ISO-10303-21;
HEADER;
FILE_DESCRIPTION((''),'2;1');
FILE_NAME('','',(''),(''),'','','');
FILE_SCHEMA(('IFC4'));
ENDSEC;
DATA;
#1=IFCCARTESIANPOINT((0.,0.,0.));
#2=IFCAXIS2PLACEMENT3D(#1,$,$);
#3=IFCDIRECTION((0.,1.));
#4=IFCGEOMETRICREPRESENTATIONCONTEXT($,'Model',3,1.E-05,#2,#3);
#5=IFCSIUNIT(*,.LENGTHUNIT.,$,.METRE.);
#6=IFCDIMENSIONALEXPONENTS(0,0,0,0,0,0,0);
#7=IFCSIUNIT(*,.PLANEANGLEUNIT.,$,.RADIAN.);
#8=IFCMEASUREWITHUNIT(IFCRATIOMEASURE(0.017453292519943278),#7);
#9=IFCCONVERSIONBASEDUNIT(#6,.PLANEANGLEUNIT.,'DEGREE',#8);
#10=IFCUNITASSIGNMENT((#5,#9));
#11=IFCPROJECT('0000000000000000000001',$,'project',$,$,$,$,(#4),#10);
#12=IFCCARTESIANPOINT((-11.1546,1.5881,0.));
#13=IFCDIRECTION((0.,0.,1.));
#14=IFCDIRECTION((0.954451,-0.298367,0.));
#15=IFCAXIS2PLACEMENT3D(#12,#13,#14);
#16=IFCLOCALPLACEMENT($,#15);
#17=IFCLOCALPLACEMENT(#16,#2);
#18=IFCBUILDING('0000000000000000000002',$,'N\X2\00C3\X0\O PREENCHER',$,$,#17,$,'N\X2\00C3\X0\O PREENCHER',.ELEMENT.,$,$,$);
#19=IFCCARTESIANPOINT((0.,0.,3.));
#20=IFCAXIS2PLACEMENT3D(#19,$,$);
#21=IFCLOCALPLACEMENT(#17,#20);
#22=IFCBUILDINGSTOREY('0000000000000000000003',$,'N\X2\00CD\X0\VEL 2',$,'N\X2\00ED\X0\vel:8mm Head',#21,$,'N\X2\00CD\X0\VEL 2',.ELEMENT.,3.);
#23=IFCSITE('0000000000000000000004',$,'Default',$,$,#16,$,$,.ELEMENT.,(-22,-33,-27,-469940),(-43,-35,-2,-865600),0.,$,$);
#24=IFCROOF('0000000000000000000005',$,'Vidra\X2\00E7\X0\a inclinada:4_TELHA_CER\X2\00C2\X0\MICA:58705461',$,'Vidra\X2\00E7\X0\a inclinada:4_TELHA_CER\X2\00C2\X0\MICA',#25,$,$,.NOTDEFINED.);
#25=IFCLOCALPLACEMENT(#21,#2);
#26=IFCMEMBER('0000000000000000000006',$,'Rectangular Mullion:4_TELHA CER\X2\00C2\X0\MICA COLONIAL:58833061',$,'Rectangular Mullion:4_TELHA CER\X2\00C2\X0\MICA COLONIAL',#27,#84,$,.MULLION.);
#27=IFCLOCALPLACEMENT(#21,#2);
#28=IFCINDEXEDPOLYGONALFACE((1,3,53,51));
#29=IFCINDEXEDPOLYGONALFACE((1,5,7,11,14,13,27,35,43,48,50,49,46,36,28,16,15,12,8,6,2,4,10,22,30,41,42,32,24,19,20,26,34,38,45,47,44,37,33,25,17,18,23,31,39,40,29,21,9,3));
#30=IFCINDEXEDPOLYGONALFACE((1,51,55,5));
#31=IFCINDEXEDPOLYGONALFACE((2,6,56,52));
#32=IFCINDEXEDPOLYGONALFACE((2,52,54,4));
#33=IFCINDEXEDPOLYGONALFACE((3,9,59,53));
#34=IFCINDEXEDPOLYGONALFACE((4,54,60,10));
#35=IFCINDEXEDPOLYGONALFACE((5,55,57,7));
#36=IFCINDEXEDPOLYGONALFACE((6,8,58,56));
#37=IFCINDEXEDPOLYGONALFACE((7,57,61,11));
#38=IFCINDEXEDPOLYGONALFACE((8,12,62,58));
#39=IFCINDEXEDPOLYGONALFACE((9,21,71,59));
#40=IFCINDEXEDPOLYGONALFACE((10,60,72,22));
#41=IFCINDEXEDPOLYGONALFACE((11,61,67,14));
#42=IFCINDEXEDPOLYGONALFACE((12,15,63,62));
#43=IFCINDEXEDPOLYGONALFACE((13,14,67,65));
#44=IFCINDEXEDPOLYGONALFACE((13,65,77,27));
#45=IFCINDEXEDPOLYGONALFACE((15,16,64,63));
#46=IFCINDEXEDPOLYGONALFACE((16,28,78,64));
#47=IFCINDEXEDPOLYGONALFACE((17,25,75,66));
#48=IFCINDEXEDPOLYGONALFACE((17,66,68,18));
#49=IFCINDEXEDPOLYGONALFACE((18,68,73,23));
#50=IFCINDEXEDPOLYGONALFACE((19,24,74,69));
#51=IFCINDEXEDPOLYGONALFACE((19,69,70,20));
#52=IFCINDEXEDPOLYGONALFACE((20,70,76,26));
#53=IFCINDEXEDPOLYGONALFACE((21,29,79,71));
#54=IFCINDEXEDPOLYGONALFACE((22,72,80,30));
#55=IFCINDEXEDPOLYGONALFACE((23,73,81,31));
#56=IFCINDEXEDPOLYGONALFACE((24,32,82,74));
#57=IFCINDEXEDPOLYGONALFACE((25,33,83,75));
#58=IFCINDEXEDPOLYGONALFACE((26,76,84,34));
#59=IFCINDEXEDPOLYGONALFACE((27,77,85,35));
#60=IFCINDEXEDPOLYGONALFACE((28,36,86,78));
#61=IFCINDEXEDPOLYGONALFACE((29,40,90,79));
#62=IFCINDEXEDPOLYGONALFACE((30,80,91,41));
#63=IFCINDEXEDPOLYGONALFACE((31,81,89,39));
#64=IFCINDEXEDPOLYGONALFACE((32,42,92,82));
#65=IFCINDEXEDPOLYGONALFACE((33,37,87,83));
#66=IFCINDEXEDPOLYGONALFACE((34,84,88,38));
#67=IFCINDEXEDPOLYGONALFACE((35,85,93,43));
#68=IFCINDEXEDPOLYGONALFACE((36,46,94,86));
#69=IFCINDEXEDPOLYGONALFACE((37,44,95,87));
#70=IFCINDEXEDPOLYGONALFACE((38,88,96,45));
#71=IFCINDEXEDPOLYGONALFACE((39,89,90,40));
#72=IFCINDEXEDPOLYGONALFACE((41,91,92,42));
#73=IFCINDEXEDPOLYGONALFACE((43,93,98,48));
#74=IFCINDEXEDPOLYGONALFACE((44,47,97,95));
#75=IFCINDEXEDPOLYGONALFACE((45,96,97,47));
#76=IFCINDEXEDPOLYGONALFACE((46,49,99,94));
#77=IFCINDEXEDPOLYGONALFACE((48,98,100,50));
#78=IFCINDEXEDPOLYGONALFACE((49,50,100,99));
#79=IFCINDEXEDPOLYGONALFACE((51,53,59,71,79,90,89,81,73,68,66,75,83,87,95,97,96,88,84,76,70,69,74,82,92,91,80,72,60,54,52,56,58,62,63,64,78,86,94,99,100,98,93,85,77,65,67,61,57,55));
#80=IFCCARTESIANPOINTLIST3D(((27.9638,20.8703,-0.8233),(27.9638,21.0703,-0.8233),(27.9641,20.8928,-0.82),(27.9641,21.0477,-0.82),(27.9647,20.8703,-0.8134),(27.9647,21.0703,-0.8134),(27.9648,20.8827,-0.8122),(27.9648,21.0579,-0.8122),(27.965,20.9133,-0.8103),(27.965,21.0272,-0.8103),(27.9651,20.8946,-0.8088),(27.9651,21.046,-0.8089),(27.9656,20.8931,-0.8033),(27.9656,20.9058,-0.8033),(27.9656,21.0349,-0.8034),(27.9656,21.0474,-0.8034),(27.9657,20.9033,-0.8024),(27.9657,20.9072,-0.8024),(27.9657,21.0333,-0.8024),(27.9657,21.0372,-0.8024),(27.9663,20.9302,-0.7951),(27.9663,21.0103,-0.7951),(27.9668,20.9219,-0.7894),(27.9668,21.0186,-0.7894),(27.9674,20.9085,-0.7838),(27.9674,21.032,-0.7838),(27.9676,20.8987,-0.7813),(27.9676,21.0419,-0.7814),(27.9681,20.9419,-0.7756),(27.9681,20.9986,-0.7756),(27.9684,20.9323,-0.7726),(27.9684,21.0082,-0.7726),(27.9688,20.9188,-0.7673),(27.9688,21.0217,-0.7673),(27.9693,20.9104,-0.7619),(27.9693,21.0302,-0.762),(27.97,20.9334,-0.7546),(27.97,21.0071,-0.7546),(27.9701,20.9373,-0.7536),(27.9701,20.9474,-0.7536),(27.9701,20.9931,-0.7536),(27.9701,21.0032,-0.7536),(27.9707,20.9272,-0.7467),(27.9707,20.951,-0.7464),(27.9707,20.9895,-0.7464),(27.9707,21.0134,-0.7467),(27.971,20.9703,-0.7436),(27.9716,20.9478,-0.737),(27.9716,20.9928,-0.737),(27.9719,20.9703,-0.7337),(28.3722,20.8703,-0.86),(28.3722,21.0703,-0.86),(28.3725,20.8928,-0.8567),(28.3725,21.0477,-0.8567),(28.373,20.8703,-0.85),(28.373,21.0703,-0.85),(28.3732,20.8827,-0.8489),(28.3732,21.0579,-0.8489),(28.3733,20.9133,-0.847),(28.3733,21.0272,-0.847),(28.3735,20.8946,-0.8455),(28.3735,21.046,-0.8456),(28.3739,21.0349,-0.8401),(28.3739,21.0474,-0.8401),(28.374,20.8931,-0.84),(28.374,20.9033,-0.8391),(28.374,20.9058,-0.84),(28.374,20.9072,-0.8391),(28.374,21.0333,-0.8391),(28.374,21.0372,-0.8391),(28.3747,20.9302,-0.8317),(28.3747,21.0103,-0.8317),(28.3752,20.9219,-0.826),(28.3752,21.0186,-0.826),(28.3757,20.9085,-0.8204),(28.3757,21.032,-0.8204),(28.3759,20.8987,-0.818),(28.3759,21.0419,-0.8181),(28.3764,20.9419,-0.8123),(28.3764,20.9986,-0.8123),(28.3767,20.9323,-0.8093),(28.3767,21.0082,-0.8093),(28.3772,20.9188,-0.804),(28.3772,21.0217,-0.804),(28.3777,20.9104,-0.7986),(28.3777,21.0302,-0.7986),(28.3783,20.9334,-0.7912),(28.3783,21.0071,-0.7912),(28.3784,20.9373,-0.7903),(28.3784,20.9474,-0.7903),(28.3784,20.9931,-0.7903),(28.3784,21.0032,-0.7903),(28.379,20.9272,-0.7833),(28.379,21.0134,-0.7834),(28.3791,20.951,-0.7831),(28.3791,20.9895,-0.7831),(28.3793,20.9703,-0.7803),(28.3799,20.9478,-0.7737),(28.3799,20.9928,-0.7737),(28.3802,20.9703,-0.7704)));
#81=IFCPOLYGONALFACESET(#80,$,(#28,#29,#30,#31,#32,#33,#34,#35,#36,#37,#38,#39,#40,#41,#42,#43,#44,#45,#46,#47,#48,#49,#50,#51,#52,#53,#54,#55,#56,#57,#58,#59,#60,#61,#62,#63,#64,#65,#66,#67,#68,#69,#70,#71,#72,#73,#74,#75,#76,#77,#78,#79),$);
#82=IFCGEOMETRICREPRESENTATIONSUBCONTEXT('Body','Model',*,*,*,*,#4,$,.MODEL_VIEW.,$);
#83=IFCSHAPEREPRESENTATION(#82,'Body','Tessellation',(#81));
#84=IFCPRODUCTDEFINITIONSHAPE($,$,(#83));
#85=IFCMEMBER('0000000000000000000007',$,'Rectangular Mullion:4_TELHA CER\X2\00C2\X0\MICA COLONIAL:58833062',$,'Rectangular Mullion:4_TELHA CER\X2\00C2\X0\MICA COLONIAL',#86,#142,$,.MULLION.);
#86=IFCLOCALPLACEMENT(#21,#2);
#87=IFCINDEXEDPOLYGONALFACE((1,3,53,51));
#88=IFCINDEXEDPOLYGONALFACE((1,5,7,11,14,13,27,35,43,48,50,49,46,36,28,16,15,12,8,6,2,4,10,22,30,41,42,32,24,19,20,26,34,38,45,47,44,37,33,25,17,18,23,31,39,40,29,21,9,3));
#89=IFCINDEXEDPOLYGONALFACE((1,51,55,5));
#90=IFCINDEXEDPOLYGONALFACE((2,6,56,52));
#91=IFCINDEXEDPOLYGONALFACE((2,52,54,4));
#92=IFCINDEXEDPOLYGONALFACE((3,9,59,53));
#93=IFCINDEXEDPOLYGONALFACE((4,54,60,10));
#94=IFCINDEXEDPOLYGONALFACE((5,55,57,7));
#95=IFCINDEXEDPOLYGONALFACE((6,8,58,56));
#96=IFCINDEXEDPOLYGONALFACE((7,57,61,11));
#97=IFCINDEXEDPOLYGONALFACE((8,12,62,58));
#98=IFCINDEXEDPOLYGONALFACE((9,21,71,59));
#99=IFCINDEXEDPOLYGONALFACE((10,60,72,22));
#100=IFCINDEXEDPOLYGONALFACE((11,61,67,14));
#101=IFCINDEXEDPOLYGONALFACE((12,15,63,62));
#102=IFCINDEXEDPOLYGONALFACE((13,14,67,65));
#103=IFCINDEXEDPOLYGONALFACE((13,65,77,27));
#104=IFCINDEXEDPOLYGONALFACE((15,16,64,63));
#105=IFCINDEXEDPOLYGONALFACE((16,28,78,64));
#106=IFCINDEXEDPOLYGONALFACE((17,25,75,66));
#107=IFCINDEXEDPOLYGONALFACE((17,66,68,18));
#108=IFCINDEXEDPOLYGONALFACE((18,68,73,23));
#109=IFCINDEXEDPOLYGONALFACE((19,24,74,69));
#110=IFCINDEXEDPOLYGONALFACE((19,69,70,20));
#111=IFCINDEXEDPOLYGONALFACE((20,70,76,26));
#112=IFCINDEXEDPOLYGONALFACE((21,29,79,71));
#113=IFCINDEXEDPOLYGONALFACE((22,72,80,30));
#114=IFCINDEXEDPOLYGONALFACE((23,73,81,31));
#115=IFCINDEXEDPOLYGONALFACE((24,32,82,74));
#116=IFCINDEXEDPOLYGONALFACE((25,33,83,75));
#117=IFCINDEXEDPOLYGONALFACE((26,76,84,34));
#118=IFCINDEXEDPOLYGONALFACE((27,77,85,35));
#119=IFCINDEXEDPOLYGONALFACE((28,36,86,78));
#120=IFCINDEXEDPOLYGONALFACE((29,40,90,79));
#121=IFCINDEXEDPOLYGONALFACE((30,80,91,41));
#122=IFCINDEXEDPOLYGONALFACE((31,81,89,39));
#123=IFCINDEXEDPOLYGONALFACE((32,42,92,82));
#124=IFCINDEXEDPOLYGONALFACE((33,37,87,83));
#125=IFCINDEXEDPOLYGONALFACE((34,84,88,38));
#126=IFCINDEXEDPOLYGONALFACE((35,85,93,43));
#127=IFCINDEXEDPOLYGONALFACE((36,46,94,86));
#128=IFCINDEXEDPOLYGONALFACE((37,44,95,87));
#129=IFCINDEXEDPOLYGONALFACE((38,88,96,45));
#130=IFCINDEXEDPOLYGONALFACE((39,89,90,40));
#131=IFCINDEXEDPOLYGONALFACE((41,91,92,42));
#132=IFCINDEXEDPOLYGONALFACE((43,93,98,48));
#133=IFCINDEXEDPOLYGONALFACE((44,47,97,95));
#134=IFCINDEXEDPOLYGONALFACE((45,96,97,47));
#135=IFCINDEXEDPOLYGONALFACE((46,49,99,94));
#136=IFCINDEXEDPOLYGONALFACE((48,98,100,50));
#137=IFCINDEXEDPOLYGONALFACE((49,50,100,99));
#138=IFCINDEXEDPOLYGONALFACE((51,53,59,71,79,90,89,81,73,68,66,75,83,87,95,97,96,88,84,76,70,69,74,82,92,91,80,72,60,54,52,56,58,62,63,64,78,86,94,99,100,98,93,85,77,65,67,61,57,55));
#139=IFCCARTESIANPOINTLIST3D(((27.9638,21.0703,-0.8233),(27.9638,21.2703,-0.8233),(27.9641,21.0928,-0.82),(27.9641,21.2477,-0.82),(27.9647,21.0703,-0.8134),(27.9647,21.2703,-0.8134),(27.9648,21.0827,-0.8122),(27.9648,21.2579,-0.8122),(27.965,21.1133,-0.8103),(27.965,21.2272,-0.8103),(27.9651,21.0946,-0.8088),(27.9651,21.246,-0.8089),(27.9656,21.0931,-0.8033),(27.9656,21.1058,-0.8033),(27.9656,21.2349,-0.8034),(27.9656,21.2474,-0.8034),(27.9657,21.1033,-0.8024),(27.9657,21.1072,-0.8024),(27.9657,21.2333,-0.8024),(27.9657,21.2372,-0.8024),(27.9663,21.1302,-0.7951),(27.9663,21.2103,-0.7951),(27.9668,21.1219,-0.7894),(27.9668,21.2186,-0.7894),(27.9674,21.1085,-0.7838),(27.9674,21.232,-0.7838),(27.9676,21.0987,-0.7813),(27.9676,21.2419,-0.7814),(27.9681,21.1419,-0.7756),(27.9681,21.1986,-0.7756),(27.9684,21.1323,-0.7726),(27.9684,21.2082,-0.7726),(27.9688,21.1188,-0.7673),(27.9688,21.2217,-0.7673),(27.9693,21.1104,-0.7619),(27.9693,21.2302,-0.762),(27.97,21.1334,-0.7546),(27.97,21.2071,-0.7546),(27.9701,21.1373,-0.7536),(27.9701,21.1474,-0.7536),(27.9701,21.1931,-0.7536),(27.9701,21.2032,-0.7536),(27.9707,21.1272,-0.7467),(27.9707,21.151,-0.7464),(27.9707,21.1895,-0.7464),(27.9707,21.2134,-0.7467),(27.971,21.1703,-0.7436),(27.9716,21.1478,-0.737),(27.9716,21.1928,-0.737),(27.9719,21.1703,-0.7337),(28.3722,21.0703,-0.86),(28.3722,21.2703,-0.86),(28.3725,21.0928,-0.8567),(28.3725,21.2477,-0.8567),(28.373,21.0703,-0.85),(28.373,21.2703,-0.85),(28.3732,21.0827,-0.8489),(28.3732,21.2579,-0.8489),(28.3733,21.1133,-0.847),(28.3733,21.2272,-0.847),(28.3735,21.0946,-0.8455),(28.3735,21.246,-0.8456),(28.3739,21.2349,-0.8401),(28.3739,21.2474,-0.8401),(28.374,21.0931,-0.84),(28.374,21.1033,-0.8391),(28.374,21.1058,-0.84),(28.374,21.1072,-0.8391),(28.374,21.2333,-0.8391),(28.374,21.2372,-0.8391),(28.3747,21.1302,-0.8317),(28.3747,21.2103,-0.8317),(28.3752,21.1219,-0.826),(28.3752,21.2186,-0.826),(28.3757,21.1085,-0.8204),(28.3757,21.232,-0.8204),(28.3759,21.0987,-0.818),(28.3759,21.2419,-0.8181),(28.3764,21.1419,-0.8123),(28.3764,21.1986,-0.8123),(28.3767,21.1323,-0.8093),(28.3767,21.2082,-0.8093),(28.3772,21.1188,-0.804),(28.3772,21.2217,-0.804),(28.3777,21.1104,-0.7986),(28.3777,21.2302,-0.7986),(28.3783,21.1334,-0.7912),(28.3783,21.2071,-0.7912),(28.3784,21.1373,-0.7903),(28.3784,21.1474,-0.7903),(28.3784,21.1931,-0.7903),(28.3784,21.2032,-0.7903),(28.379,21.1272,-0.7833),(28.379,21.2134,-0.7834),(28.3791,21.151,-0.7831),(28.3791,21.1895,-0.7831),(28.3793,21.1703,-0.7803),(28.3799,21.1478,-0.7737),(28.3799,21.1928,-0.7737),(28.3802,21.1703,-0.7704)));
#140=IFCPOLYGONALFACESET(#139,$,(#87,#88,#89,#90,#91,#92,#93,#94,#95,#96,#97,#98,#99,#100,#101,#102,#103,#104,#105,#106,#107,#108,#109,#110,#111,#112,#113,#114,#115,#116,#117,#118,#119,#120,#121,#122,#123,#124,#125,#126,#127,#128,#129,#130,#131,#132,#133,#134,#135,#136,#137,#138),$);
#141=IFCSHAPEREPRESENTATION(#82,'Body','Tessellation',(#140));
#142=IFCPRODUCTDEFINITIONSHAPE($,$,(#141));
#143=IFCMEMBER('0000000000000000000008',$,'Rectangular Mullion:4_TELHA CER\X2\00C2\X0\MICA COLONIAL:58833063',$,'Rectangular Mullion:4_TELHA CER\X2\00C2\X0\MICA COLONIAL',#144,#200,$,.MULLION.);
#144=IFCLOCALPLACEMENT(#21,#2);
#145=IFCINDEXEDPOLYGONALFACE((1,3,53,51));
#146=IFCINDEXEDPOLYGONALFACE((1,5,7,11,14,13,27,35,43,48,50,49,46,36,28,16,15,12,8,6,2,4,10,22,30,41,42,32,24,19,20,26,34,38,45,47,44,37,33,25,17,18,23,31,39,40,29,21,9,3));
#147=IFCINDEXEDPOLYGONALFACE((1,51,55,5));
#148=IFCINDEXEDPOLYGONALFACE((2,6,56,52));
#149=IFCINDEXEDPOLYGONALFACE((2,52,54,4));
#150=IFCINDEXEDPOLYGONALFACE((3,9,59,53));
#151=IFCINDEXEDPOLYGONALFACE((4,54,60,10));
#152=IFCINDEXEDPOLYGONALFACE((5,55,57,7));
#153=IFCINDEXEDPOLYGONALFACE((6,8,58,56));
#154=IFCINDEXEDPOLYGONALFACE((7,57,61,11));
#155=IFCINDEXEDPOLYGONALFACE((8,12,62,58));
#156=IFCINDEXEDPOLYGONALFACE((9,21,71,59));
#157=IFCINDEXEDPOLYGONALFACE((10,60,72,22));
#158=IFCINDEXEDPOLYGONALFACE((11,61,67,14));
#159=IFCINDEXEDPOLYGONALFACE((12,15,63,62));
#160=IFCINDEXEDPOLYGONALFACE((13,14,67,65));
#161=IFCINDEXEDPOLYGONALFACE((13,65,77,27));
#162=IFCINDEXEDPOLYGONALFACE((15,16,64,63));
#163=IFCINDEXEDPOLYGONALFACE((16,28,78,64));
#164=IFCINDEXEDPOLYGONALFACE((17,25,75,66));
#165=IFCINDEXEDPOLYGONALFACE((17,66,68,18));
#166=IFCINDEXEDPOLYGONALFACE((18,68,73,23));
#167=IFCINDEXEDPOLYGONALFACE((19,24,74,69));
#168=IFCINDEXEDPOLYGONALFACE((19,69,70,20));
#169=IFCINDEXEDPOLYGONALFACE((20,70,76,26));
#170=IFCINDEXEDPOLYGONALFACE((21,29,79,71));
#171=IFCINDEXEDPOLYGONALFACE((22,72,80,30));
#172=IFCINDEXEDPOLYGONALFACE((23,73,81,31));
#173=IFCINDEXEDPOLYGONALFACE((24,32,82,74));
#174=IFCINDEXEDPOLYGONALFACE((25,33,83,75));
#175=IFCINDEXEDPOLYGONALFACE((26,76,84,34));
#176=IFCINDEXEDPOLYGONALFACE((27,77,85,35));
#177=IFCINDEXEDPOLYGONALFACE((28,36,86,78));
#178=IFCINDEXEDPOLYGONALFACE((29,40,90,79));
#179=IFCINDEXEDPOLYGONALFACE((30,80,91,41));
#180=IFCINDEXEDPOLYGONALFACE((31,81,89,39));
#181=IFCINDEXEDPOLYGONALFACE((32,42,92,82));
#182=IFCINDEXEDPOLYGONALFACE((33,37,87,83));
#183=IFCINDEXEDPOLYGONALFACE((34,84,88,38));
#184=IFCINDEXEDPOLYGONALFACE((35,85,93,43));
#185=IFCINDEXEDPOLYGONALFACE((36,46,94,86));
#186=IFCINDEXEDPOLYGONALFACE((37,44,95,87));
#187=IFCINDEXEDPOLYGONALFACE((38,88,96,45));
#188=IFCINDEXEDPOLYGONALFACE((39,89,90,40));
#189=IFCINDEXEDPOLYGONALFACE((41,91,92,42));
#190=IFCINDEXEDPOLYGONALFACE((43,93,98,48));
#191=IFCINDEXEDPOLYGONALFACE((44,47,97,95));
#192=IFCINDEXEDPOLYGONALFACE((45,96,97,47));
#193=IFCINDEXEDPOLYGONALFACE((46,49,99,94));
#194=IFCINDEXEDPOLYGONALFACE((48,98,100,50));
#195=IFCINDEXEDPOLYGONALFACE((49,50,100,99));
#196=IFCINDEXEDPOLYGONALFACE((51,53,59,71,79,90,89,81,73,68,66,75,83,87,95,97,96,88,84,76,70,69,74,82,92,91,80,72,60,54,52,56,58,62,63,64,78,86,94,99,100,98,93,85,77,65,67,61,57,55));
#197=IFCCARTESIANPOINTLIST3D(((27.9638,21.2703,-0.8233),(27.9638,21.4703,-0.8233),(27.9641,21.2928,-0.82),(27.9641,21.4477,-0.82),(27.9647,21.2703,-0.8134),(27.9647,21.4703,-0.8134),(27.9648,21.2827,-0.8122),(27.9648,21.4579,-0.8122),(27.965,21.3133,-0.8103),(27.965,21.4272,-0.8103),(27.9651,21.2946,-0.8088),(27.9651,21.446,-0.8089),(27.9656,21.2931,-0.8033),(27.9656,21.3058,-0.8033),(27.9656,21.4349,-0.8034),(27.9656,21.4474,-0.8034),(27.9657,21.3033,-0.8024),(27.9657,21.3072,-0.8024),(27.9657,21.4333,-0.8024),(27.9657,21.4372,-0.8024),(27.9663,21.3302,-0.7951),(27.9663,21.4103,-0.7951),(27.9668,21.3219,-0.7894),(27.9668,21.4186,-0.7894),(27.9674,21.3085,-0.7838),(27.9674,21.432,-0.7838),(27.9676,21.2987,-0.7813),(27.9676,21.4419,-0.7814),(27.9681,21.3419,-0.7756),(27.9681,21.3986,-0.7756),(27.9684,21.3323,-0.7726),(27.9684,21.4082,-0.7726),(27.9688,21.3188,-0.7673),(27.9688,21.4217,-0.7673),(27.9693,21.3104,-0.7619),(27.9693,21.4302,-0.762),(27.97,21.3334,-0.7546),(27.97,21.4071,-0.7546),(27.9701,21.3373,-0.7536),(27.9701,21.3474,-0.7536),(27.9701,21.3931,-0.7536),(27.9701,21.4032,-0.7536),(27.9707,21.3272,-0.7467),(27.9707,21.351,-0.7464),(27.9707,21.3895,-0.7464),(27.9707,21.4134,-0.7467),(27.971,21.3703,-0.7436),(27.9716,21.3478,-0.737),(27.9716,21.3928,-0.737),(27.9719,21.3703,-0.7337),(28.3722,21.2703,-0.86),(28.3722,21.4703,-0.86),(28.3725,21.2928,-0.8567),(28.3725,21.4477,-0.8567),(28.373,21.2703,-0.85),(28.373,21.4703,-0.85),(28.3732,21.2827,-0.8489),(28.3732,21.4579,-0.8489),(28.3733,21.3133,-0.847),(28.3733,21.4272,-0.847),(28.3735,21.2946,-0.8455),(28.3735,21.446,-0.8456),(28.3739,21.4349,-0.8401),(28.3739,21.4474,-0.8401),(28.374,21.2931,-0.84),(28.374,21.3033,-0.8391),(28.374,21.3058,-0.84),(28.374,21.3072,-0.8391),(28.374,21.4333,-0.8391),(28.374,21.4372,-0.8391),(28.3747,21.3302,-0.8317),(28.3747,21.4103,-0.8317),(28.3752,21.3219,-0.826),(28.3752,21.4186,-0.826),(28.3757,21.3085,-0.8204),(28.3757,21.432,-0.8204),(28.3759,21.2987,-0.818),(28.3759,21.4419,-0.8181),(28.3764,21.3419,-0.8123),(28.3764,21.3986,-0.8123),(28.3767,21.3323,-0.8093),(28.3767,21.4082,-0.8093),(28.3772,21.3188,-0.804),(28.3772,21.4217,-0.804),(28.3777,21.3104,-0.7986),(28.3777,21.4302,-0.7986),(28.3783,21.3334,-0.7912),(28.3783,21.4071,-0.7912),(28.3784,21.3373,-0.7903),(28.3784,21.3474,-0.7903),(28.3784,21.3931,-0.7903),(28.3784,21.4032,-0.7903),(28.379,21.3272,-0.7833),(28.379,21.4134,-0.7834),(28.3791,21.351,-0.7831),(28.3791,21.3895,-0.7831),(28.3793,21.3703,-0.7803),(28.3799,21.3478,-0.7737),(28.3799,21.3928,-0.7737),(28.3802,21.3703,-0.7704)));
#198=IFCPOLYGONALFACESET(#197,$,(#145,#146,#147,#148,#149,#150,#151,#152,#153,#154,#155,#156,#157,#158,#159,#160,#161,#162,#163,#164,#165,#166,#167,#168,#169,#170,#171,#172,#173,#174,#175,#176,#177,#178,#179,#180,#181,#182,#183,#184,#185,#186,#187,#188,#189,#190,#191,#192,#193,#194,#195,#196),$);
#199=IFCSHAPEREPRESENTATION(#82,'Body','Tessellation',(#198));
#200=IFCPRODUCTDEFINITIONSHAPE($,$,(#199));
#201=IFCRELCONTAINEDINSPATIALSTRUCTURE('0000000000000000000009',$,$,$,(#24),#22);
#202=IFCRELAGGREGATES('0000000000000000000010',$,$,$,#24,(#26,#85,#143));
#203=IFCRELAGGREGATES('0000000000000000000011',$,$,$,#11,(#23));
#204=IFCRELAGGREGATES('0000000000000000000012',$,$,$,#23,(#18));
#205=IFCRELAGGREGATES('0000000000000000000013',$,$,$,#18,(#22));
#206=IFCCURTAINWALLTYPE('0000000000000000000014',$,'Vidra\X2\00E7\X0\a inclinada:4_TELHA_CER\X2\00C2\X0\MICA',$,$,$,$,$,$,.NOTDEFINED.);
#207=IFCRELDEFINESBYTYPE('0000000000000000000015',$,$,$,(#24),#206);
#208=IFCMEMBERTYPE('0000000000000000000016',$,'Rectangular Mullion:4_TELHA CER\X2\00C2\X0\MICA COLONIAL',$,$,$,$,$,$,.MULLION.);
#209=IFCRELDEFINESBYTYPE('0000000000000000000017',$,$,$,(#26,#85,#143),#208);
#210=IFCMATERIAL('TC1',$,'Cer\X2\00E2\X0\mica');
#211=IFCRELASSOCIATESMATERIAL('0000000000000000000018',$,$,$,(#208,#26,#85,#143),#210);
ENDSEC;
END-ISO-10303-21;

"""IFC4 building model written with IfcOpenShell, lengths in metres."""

from ifc_helpers import new_model, entity, si_unit, converted_unit, direction, frame, origin, place, context, subcontext, project, spatial, line, arc, indexed_curve, outline, extrude, source, transform, mapped, material, type_object, type_shapes, element, aggregate, save


model = new_model("IFC4")

# Units and contexts
model_context = context("Model", 3, precision=1e-05, world=origin(), true_north=direction((0.0, 1.0)))
body_context = subcontext(model_context, "Body", "Model", "MODEL_VIEW")
ifc_project = project(units=[si_unit("LENGTHUNIT", "METRE"), converted_unit("PLANEANGLEUNIT", "DEGREE", entity("IfcRatioMeasure", 0.017453292519943278), si_unit("PLANEANGLEUNIT", "RADIAN"), dimensions=[0, 0, 0, 0, 0, 0, 0])], contexts=[model_context])

# Site, building, storey
site_placement = place(None, frame((-11.1546, 1.5881, 0.0), z_axis=(0.0, 0.0, 1.0), x_axis=(0.954451, -0.298367, 0.0)))
site = spatial("IfcSite", under=ifc_project, at=site_placement, Name="Default", CompositionType="ELEMENT", RefLatitude=(-22, -33, -27, -469940), RefLongitude=(-43, -35, -2, -865600), RefElevation=0.0)
building_placement = place(site_placement, origin())
building = spatial("IfcBuilding", under=site, at=building_placement, Name="NÃO PREENCHER", LongName="NÃO PREENCHER", CompositionType="ELEMENT")
storey_placement = place(building_placement, frame((0.0, 0.0, 3.0)))
storey = spatial("IfcBuildingStorey", under=building, at=storey_placement, Name="NÍVEL 2", ObjectType="Nível:8mm Head", LongName="NÍVEL 2", CompositionType="ELEMENT", Elevation=3.0)

# Roof, members
curtain_wall_type = type_object("IfcCurtainWallType", Name="Vidraça inclinada:4_TELHA_CERÂMICA", PredefinedType="NOTDEFINED")
roof_placement = place(storey_placement, frame((0.0, 0.0, -3.0)))
roof = element("IfcRoof", 1, at=roof_placement, inside=storey, type_object=curtain_wall_type, Name="Vidraça inclinada:4_TELHA_CERÂMICA:58705461", ObjectType="Vidraça inclinada:4_TELHA_CERÂMICA", PredefinedType="NOTDEFINED")
ifc_material = material(Name="TC1", Category="Cerâmica")
member_type_1 = type_object("IfcMemberType", Name="Rectangular Mullion:4_TELHA CERÂMICA COLONIAL", PredefinedType="MULLION", material=ifc_material)
shared_shape_1 = source(origin(), body_context, "Body", "SweptSolid", [
    extrude(outline(indexed_curve([(-0.029, -0.1), (-0.019, -0.1), (-0.0164, -0.0815), (-0.0089, -0.0645), (-0.0089, -0.0771), (0.061, 0.0), (-0.009, 0.0771), (-0.009, 0.0646), (-0.0165, 0.0816), (-0.019, 0.1), (-0.029, 0.1), (-0.0089, 0.0479), (0.041, 0.0229), (0.041, 0.0329), (0.0131, 0.0425), (-0.008, 0.0631), (-0.008, 0.067), (0.051, 0.0), (-0.008, -0.067), (-0.008, -0.0631), (0.0131, -0.0425), (0.041, -0.0329), (0.041, -0.0229), (-0.0089, -0.0479)], segments=[line(1, 2), arc(2, 3, 4), line(4, 5), arc(5, 6, 7), line(7, 8), arc(8, 9, 10), line(10, 11), arc(11, 12, 13), line(13, 14), arc(14, 15, 16), line(16, 17), arc(17, 18, 19), line(19, 20), arc(20, 21, 22), line(22, 23), arc(23, 24, 1)], self_intersect=False)), frame((0.0, -0.029, -0.41), z_axis=(0.0, 0.0, 1.0), x_axis=(0.0, -1.0, 0.0)), (0.0, 0.0, 1.0), 0.41),
])
type_shapes(member_type_1, [shared_shape_1])
member_1_placement = place(roof_placement, frame((27.9638, 20.9703, 2.1767), z_axis=(-0.99599, 0.0, 0.089469), x_axis=(0.0, 1.0, 0.0)))
member_1 = element("IfcMember", 2, at=member_1_placement, type_object=member_type_1, material=ifc_material, Name="Rectangular Mullion:4_TELHA CERÂMICA COLONIAL:58833061", ObjectType="Rectangular Mullion:4_TELHA CERÂMICA COLONIAL", PredefinedType="MULLION", context=body_context, shape_type="MappedRepresentation", body=[
    mapped(shared_shape_1, transform((0.0, 0.0, 0.0), scale=1.0)),
])
member_2_placement = place(roof_placement, frame((27.9638, 21.1703, 2.1767), z_axis=(-0.99599, 0.0, 0.089469), x_axis=(0.0, 1.0, 0.0)))
member_2 = element("IfcMember", 3, at=member_2_placement, type_object=member_type_1, material=ifc_material, Name="Rectangular Mullion:4_TELHA CERÂMICA COLONIAL:58833062", ObjectType="Rectangular Mullion:4_TELHA CERÂMICA COLONIAL", PredefinedType="MULLION", context=body_context, shape_type="MappedRepresentation", body=[
    mapped(shared_shape_1, transform((0.0, 0.0, 0.0), scale=1.0)),
])
member_3_placement = place(roof_placement, frame((27.9638, 21.3703, 2.1767), z_axis=(-0.99599, 0.0, 0.089469), x_axis=(0.0, 1.0, 0.0)))
member_3 = element("IfcMember", 4, at=member_3_placement, type_object=member_type_1, material=ifc_material, Name="Rectangular Mullion:4_TELHA CERÂMICA COLONIAL:58833063", ObjectType="Rectangular Mullion:4_TELHA CERÂMICA COLONIAL", PredefinedType="MULLION", context=body_context, shape_type="MappedRepresentation", body=[
    mapped(shared_shape_1, transform((0.0, 0.0, 0.0), scale=1.0)),
])
aggregate(roof, [member_1, member_2, member_3])

save(model, "model.ifc")
